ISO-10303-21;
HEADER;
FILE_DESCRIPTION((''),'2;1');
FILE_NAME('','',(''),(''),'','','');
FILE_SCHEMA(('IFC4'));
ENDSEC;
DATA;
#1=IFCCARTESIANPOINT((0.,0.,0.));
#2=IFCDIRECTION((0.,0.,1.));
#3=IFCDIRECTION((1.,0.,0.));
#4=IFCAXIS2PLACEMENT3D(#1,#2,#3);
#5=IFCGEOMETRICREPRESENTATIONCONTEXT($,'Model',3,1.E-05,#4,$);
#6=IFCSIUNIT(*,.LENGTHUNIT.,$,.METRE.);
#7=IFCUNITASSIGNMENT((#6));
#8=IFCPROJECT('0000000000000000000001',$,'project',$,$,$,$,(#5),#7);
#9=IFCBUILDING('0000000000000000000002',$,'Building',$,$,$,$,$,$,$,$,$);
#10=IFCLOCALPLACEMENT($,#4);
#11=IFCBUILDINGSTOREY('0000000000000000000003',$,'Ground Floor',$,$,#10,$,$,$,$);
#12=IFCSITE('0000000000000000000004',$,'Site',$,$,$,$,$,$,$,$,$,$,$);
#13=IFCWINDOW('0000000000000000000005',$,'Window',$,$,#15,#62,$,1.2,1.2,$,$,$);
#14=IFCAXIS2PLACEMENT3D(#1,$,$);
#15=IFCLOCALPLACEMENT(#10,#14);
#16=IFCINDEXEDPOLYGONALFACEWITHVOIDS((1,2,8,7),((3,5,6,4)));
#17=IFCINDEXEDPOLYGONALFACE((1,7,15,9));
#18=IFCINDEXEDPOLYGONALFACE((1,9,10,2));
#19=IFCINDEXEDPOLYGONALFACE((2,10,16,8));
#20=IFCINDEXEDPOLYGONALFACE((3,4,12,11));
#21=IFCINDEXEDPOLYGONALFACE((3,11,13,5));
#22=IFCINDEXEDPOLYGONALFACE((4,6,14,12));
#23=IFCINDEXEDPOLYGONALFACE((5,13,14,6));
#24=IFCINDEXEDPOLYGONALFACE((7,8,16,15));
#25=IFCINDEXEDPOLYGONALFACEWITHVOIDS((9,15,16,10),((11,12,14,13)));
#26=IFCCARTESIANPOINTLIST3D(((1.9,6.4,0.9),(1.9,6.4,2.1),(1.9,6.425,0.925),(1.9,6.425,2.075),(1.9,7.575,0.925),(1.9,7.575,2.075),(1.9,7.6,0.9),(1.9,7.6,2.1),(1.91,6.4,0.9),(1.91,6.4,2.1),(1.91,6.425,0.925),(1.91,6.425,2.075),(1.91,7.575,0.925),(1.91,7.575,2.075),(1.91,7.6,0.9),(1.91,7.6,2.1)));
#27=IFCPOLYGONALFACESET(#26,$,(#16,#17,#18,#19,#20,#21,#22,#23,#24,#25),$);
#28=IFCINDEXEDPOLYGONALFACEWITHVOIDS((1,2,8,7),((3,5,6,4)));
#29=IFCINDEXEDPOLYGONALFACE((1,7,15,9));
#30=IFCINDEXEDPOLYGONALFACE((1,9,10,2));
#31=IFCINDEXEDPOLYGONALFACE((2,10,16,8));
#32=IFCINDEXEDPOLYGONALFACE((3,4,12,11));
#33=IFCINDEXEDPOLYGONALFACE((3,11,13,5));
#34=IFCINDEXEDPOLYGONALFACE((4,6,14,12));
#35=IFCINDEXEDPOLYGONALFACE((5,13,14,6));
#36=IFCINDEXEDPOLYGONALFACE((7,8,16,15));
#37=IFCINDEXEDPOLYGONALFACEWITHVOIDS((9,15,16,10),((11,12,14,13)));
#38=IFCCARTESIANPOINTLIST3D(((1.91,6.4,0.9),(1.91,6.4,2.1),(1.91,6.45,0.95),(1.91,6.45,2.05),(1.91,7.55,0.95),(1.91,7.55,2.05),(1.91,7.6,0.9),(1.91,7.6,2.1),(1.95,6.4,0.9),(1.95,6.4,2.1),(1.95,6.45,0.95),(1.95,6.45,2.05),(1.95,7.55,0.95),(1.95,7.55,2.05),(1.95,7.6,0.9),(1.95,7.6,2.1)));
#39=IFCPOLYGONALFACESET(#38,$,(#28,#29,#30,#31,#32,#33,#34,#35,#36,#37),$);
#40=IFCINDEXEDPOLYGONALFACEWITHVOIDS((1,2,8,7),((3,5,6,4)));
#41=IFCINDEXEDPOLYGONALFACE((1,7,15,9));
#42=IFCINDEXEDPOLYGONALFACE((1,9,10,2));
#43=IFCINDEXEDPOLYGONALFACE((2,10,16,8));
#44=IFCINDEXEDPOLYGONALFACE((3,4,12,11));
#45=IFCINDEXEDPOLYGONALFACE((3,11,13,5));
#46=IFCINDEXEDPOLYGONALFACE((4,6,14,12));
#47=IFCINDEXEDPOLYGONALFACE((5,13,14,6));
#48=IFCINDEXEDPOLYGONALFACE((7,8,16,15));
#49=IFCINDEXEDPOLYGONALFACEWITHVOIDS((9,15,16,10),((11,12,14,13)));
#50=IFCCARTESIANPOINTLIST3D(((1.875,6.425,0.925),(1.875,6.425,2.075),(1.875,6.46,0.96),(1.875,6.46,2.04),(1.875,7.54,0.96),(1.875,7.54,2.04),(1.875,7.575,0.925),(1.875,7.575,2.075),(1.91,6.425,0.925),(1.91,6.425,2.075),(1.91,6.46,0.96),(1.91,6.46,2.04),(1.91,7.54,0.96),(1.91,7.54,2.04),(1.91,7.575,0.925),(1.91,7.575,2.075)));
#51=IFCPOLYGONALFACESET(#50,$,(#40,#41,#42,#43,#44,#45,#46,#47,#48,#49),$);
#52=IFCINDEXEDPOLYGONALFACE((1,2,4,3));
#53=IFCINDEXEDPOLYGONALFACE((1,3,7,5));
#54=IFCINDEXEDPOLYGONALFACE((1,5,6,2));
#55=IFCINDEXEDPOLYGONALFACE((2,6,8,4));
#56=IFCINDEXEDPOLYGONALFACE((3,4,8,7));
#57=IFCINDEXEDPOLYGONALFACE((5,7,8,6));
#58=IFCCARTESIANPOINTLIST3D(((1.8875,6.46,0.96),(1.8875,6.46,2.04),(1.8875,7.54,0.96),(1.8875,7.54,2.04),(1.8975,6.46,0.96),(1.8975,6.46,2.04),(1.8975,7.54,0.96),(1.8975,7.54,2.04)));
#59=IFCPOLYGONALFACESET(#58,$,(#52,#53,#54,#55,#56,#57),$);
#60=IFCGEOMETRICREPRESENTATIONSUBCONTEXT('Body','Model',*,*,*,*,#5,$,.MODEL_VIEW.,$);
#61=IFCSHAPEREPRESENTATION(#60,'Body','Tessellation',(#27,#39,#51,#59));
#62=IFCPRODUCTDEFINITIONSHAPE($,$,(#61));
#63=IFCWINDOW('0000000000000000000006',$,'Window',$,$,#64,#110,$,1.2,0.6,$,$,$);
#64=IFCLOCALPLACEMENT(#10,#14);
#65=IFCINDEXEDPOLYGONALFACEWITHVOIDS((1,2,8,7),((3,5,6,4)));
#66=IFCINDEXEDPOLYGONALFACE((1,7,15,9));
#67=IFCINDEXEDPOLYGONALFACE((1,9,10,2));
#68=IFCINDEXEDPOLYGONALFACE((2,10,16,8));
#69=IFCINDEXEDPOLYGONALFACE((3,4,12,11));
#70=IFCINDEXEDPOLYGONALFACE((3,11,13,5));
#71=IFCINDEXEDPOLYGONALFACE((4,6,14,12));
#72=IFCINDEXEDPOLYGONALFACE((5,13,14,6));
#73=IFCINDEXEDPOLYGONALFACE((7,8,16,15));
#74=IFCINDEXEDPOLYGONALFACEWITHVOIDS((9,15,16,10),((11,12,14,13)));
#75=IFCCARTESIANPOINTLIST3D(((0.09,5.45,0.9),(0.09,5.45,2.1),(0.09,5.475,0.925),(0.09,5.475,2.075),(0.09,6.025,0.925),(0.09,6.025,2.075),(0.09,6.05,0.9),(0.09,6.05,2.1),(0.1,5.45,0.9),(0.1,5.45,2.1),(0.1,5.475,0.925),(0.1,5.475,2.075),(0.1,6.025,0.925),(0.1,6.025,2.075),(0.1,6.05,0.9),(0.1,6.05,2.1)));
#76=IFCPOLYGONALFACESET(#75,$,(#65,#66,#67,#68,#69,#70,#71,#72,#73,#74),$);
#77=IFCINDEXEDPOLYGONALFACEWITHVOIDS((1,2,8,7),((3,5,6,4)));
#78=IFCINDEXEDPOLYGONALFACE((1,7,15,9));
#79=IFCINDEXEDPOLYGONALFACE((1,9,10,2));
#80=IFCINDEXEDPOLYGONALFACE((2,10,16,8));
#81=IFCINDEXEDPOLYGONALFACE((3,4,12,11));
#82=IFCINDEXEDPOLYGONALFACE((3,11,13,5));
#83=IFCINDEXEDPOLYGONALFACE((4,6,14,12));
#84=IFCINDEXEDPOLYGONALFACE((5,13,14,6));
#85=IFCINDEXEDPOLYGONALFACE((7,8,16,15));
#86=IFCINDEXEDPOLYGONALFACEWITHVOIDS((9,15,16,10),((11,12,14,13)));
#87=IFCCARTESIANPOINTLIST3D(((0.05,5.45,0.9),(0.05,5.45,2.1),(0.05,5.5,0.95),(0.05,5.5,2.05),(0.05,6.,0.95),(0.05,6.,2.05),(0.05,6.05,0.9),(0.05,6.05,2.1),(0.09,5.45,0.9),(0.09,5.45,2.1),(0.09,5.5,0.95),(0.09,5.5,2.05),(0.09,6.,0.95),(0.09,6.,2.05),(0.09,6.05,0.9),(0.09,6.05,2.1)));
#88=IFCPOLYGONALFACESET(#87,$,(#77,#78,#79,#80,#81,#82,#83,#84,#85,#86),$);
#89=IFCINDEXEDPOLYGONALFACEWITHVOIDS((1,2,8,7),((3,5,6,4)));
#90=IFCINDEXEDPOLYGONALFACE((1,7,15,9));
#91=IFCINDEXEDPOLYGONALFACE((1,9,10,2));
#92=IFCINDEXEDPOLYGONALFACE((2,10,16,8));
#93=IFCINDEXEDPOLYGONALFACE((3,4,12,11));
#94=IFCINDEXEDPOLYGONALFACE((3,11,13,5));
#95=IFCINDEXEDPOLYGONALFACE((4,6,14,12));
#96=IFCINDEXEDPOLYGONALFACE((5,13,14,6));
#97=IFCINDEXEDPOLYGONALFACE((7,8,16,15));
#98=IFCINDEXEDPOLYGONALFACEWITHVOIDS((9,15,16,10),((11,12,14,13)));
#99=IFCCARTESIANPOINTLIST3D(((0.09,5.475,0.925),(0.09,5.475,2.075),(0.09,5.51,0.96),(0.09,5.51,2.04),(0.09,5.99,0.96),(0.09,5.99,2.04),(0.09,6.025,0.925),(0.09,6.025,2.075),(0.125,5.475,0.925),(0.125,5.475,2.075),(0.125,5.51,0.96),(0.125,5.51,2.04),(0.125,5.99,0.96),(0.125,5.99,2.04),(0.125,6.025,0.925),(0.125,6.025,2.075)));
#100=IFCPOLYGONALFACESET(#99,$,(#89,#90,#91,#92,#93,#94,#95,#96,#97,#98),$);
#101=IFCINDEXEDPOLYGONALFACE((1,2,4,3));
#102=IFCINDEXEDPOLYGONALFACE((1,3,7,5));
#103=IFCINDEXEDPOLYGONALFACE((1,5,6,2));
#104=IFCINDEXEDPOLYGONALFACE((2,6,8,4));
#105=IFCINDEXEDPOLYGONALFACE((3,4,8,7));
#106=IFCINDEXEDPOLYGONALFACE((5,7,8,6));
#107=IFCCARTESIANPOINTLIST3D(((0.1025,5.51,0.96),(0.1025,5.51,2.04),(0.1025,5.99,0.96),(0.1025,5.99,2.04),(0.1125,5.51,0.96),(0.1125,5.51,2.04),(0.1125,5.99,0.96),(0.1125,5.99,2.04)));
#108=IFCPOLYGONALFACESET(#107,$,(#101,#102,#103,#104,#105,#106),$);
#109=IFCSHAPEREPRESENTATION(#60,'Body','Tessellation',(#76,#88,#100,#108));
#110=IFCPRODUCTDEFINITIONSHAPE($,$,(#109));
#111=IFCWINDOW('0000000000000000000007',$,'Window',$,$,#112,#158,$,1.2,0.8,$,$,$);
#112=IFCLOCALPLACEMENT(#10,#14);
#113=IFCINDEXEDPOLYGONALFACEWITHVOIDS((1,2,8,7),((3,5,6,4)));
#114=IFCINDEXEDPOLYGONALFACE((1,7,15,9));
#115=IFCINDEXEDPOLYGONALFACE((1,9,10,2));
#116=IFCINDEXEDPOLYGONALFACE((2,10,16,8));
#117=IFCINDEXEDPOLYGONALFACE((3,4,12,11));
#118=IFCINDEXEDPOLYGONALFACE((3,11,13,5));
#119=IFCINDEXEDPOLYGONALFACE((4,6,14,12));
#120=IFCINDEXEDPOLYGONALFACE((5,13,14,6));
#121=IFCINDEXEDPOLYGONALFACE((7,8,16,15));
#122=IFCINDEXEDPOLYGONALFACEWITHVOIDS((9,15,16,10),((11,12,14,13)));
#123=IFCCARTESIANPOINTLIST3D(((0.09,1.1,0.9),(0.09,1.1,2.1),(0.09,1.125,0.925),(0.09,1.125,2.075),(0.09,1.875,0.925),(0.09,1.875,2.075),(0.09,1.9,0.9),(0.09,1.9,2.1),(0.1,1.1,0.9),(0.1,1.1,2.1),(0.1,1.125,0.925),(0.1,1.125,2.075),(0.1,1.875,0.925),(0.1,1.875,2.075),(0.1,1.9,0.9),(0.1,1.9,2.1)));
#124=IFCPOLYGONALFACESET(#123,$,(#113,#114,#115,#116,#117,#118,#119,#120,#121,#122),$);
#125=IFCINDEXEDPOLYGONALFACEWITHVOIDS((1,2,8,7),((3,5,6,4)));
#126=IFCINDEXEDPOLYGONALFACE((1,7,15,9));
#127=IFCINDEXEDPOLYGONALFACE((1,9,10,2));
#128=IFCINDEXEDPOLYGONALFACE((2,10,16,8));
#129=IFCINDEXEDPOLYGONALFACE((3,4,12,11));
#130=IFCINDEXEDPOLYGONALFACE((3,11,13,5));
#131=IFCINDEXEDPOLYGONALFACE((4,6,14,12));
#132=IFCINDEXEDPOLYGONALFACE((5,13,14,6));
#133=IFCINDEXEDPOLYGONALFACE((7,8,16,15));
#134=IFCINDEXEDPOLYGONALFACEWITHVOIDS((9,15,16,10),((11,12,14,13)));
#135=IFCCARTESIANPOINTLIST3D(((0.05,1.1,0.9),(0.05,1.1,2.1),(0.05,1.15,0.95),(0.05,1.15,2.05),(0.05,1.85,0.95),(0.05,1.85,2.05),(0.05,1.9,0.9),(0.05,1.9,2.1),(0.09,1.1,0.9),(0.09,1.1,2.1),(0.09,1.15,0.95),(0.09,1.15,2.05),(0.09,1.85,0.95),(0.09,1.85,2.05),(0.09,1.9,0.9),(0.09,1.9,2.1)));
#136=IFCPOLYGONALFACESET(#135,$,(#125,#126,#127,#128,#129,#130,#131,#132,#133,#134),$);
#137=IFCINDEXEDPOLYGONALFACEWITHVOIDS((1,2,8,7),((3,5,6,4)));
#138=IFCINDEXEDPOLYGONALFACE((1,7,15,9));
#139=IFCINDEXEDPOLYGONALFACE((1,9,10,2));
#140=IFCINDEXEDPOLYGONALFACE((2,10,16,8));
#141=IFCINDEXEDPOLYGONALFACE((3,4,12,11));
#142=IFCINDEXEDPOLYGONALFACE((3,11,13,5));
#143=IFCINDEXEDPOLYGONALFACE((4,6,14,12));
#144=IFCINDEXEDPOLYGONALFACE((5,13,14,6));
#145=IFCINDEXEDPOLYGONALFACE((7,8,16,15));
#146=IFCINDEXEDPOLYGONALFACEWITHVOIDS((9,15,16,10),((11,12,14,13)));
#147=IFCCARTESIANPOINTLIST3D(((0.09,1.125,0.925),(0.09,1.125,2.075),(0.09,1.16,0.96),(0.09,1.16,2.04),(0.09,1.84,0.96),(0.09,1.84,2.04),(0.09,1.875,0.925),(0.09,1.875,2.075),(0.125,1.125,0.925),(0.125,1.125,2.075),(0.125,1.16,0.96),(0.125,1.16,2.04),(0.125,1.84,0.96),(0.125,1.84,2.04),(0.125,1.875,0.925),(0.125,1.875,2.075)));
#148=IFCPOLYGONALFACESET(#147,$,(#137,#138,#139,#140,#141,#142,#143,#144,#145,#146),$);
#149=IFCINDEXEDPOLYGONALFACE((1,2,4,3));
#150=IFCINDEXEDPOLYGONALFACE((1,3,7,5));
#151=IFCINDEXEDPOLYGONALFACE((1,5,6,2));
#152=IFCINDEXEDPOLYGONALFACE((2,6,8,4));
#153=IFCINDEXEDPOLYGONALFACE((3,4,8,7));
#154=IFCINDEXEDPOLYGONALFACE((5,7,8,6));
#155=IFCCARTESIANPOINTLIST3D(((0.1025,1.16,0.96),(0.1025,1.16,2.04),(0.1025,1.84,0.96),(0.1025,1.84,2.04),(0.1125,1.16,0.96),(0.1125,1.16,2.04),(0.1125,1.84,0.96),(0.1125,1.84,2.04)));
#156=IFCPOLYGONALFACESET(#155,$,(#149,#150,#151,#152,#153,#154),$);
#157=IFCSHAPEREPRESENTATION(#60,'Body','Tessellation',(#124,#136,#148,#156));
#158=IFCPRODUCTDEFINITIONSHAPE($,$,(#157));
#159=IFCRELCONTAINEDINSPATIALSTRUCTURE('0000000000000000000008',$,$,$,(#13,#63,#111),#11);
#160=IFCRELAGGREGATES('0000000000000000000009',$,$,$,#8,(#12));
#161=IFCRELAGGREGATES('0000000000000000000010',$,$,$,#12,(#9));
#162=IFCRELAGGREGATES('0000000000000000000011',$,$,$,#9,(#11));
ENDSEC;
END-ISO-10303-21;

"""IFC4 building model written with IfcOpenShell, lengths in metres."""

from ifc_helpers import new_model, si_unit, frame, origin_with_axes, place, context, subcontext, project, spatial, line, indexed_curve, outline, extrude, element, save


model = new_model("IFC4")

# Units and contexts
model_context = context("Model", 3, precision=1e-05, world=origin_with_axes())
body_context = subcontext(model_context, "Body", "Model", "MODEL_VIEW")
ifc_project = project(units=[si_unit("LENGTHUNIT", "METRE")], contexts=[model_context])

# Site, building, storey
site = spatial("IfcSite", under=ifc_project, Name="Site")
building = spatial("IfcBuilding", under=site, Name="Building")
storey_placement = place(None, origin_with_axes())
storey = spatial("IfcBuildingStorey", under=building, at=storey_placement, Name="Ground Floor")

# Windows
window_1_placement = place(storey_placement, frame((2.0, 6.4, 0.9), z_axis=(0.0, 0.0, 1.0), x_axis=(0.0, 1.0, 0.0)))
element("IfcWindow", 1, at=window_1_placement, inside=storey, Name="Window", OverallHeight=1.2, OverallWidth=1.2, context=body_context, shape_type="SweptSolid", body=[
    extrude(outline(indexed_curve([(0.0, 0.0), (1.2, 0.0), (1.2, 1.2), (0.0, 1.2)], segments=[line(1, 2, 3, 4, 1)]), holes=[indexed_curve([(0.025, 0.025), (1.175, 0.025), (1.175, 1.175), (0.025, 1.175)], segments=[line(1, 2, 3, 4, 1)])]), frame((0.0, 0.09, 0.0), z_axis=(0.0, -1.0, 0.0), x_axis=(1.0, 0.0, 0.0)), (0.0, 0.0, -1.0), 0.01),
    extrude(outline(indexed_curve([(0.0, 0.0), (1.2, 0.0), (1.2, 1.2), (0.0, 1.2)], segments=[line(1, 2, 3, 4, 1)]), holes=[indexed_curve([(0.05, 0.05), (1.15, 0.05), (1.15, 1.15), (0.05, 1.15)], segments=[line(1, 2, 3, 4, 1)])]), frame((0.0, 0.05, 0.0), z_axis=(0.0, -1.0, 0.0), x_axis=(1.0, 0.0, 0.0)), (0.0, 0.0, -1.0), 0.04),
    extrude(outline(indexed_curve([(0.0, 0.0), (1.15, 0.0), (1.15, 1.15), (0.0, 1.15)], segments=[line(1, 2, 3, 4, 1)]), holes=[indexed_curve([(0.035, 0.035), (1.115, 0.035), (1.115, 1.115), (0.035, 1.115)], segments=[line(1, 2, 3, 4, 1)])]), frame((0.025, 0.09, 0.025), z_axis=(0.0, -1.0, 0.0), x_axis=(1.0, 0.0, 0.0)), (0.0, 0.0, -1.0), 0.035),
    extrude(outline(indexed_curve([(0.035, 0.035), (1.115, 0.035), (1.115, 1.115), (0.035, 1.115)], segments=[line(1, 2, 3, 4, 1)])), frame((0.025, 0.1025, 0.025), z_axis=(0.0, -1.0, 0.0), x_axis=(1.0, 0.0, 0.0)), (0.0, 0.0, -1.0), 0.01),
])
window_2_placement = place(storey_placement, frame((0.0, 6.05, 0.9), z_axis=(0.0, 0.0, 1.0), x_axis=(0.0, -1.0, 0.0)))
element("IfcWindow", 2, at=window_2_placement, inside=storey, Name="Window", OverallHeight=1.2, OverallWidth=0.6, context=body_context, shape_type="SweptSolid", body=[
    extrude(outline(indexed_curve([(0.0, 0.0), (0.6, 0.0), (0.6, 1.2), (0.0, 1.2)], segments=[line(1, 2, 3, 4, 1)]), holes=[indexed_curve([(0.025, 0.025), (0.575, 0.025), (0.575, 1.175), (0.025, 1.175)], segments=[line(1, 2, 3, 4, 1)])]), frame((0.0, 0.09, 0.0), z_axis=(0.0, -1.0, 0.0), x_axis=(1.0, 0.0, 0.0)), (0.0, 0.0, -1.0), 0.01),
    extrude(outline(indexed_curve([(0.0, 0.0), (0.6, 0.0), (0.6, 1.2), (0.0, 1.2)], segments=[line(1, 2, 3, 4, 1)]), holes=[indexed_curve([(0.05, 0.05), (0.55, 0.05), (0.55, 1.15), (0.05, 1.15)], segments=[line(1, 2, 3, 4, 1)])]), frame((0.0, 0.05, 0.0), z_axis=(0.0, -1.0, 0.0), x_axis=(1.0, 0.0, 0.0)), (0.0, 0.0, -1.0), 0.04),
    extrude(outline(indexed_curve([(0.0, 0.0), (0.55, 0.0), (0.55, 1.15), (0.0, 1.15)], segments=[line(1, 2, 3, 4, 1)]), holes=[indexed_curve([(0.035, 0.035), (0.515, 0.035), (0.515, 1.115), (0.035, 1.115)], segments=[line(1, 2, 3, 4, 1)])]), frame((0.025, 0.09, 0.025), z_axis=(0.0, -1.0, 0.0), x_axis=(1.0, 0.0, 0.0)), (0.0, 0.0, -1.0), 0.035),
    extrude(outline(indexed_curve([(0.035, 0.035), (0.515, 0.035), (0.515, 1.115), (0.035, 1.115)], segments=[line(1, 2, 3, 4, 1)])), frame((0.025, 0.1025, 0.025), z_axis=(0.0, -1.0, 0.0), x_axis=(1.0, 0.0, 0.0)), (0.0, 0.0, -1.0), 0.01),
])
window_3_placement = place(storey_placement, frame((0.0, 1.9, 0.9), z_axis=(0.0, 0.0, 1.0), x_axis=(0.0, -1.0, 0.0)))
element("IfcWindow", 3, at=window_3_placement, inside=storey, Name="Window", OverallHeight=1.2, OverallWidth=0.8, context=body_context, shape_type="SweptSolid", body=[
    extrude(outline(indexed_curve([(0.0, 0.0), (0.8, 0.0), (0.8, 1.2), (0.0, 1.2)], segments=[line(1, 2, 3, 4, 1)]), holes=[indexed_curve([(0.025, 0.025), (0.775, 0.025), (0.775, 1.175), (0.025, 1.175)], segments=[line(1, 2, 3, 4, 1)])]), frame((0.0, 0.09, 0.0), z_axis=(0.0, -1.0, 0.0), x_axis=(1.0, 0.0, 0.0)), (0.0, 0.0, -1.0), 0.01),
    extrude(outline(indexed_curve([(0.0, 0.0), (0.8, 0.0), (0.8, 1.2), (0.0, 1.2)], segments=[line(1, 2, 3, 4, 1)]), holes=[indexed_curve([(0.05, 0.05), (0.75, 0.05), (0.75, 1.15), (0.05, 1.15)], segments=[line(1, 2, 3, 4, 1)])]), frame((0.0, 0.05, 0.0), z_axis=(0.0, -1.0, 0.0), x_axis=(1.0, 0.0, 0.0)), (0.0, 0.0, -1.0), 0.04),
    extrude(outline(indexed_curve([(0.0, 0.0), (0.75, 0.0), (0.75, 1.15), (0.0, 1.15)], segments=[line(1, 2, 3, 4, 1)]), holes=[indexed_curve([(0.035, 0.035), (0.715, 0.035), (0.715, 1.115), (0.035, 1.115)], segments=[line(1, 2, 3, 4, 1)])]), frame((0.025, 0.09, 0.025), z_axis=(0.0, -1.0, 0.0), x_axis=(1.0, 0.0, 0.0)), (0.0, 0.0, -1.0), 0.035),
    extrude(outline(indexed_curve([(0.035, 0.035), (0.715, 0.035), (0.715, 1.115), (0.035, 1.115)], segments=[line(1, 2, 3, 4, 1)])), frame((0.025, 0.1025, 0.025), z_axis=(0.0, -1.0, 0.0), x_axis=(1.0, 0.0, 0.0)), (0.0, 0.0, -1.0), 0.01),
])

save(model, "model.ifc")
